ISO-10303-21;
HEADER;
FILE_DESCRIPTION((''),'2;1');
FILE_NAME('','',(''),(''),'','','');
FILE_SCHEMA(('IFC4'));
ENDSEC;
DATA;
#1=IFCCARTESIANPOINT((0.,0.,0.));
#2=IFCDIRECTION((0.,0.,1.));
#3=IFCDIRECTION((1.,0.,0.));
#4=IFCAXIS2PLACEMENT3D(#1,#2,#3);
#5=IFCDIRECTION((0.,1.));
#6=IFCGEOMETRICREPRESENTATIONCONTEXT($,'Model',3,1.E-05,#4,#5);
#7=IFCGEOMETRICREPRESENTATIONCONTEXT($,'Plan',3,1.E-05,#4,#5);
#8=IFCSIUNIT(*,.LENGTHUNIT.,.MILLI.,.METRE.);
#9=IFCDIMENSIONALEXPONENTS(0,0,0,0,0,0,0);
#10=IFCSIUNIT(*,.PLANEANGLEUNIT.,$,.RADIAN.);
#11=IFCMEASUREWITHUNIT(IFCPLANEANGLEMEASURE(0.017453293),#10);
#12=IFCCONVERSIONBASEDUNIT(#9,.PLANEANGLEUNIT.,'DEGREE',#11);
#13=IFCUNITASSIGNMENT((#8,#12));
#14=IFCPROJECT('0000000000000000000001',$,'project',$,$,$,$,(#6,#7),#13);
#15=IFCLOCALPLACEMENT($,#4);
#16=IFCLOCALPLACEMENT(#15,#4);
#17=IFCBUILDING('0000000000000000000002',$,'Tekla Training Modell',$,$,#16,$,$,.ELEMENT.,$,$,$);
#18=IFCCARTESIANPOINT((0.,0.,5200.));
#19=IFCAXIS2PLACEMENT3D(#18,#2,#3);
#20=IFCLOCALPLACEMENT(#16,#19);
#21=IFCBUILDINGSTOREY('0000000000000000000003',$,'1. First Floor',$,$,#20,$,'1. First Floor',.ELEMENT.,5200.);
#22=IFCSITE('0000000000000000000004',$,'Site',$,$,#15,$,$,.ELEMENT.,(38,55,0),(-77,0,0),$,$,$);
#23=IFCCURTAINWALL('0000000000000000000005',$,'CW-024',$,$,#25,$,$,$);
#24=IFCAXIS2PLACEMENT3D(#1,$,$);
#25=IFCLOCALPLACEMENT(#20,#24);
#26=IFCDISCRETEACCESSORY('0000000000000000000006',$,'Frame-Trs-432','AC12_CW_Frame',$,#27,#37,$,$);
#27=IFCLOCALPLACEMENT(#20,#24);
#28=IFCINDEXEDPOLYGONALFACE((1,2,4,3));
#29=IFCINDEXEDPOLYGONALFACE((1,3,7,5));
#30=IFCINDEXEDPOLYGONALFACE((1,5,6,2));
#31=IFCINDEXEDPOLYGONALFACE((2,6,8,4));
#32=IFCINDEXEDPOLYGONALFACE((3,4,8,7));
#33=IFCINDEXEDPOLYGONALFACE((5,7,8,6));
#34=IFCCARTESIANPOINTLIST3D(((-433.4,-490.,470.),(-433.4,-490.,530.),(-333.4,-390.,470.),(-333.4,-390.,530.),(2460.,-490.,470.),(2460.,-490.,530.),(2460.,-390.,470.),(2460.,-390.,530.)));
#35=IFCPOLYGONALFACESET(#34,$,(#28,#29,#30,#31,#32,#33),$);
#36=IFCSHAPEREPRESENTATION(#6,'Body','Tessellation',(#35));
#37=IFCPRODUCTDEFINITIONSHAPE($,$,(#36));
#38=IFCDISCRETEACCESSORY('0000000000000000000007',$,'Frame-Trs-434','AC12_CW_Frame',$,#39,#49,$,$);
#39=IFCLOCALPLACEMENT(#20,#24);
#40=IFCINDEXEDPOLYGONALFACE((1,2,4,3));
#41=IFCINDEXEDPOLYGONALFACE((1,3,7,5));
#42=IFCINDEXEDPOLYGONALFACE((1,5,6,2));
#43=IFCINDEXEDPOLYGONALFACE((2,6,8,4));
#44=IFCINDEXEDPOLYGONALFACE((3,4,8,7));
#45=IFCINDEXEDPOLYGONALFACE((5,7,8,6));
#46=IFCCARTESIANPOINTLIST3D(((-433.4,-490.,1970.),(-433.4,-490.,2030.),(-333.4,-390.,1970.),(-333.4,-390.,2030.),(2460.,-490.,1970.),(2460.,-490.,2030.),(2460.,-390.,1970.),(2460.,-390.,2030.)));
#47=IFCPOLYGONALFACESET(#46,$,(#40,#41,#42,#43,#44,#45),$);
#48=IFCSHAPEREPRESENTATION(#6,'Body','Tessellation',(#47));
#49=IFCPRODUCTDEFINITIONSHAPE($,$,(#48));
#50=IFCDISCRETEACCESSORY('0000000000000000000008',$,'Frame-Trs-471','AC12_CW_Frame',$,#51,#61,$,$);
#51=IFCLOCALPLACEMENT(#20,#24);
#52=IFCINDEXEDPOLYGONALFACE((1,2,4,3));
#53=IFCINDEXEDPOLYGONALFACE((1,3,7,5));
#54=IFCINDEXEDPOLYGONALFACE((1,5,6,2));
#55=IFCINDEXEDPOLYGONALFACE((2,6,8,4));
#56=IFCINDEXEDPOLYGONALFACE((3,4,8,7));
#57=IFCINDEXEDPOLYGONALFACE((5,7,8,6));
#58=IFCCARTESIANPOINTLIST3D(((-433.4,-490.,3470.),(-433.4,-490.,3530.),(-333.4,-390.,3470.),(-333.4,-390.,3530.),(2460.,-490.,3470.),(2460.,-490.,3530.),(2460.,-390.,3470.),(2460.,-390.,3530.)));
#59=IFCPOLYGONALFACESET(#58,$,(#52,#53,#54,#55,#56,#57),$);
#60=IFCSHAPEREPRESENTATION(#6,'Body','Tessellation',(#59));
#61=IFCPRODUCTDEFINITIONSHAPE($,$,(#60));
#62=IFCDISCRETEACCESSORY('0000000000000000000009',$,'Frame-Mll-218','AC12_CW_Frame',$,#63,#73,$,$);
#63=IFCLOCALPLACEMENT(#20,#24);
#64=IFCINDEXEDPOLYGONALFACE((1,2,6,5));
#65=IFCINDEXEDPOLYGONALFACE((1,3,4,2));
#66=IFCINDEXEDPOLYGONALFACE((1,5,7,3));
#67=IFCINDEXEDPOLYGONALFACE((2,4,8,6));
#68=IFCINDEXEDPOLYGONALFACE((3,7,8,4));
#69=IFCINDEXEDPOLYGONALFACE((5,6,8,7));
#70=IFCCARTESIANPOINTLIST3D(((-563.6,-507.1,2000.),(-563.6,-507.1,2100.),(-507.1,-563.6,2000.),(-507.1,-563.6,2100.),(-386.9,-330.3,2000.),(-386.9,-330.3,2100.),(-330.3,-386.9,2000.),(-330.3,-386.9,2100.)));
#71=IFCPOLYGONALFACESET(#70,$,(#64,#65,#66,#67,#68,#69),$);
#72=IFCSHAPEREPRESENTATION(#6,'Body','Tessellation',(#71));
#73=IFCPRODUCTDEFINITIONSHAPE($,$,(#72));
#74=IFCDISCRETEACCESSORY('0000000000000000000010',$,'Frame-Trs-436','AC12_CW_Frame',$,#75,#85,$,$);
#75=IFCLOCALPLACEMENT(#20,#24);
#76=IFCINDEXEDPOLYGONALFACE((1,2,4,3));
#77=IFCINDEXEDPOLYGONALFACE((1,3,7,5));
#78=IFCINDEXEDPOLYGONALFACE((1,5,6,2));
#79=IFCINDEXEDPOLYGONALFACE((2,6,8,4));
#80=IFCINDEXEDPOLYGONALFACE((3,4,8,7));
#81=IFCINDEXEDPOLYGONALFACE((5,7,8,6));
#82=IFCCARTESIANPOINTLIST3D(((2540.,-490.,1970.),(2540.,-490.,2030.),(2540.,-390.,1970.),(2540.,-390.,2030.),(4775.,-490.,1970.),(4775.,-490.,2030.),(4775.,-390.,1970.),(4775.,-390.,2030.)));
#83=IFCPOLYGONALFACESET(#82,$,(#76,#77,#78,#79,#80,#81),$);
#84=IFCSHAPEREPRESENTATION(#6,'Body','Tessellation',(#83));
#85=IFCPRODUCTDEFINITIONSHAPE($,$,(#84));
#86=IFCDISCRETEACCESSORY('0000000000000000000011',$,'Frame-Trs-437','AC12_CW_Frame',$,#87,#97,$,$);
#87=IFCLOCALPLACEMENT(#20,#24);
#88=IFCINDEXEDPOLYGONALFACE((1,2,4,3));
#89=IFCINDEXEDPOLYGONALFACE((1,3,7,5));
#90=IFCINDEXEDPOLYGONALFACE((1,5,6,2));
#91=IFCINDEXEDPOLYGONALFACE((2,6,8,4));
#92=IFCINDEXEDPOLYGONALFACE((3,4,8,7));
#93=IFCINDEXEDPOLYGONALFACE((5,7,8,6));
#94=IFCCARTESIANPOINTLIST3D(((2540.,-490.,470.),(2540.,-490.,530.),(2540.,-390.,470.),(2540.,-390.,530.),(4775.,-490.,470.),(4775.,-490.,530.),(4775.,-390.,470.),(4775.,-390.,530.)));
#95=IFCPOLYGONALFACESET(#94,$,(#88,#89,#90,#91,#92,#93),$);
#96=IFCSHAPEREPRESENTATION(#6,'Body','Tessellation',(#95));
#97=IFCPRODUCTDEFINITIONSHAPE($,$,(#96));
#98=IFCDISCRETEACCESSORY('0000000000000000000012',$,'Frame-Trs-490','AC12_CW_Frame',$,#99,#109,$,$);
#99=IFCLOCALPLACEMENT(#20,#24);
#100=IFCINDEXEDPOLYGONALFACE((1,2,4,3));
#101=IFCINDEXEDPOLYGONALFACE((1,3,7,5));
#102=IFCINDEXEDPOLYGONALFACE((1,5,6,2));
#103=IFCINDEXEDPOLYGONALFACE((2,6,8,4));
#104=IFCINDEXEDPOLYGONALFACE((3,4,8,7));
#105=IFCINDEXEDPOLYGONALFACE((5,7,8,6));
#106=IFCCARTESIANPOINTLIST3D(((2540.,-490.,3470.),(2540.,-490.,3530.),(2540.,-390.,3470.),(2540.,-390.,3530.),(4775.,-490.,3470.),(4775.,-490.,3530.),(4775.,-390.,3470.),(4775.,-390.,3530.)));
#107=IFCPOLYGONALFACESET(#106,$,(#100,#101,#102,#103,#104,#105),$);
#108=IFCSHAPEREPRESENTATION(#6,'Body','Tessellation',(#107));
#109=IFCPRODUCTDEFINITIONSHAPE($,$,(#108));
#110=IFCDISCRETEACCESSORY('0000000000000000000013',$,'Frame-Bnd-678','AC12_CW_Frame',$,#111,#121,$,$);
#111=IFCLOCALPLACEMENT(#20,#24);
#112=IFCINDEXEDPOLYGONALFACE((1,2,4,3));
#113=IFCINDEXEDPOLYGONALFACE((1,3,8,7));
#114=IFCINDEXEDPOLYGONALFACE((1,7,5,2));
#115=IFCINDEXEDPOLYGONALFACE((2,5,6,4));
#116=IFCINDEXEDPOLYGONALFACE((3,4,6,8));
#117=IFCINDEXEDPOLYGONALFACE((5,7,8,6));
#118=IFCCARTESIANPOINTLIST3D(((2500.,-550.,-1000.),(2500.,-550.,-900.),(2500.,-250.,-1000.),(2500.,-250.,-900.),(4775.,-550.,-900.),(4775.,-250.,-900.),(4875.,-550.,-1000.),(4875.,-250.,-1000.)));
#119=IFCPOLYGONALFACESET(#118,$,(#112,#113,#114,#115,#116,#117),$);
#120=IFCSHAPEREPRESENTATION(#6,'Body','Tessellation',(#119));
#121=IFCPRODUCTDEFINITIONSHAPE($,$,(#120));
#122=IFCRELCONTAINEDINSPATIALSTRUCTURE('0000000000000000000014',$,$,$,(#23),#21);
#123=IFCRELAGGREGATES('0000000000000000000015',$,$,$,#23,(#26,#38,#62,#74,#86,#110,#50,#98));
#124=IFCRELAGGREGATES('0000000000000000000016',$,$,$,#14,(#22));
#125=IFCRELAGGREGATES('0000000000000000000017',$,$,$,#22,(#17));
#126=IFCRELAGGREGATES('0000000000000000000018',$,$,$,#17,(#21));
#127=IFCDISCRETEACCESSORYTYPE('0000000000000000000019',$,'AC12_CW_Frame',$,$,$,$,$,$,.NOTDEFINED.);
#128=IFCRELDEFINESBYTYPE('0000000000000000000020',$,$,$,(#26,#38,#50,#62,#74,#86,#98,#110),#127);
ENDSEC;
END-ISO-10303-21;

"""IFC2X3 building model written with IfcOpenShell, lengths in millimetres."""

from ifc_helpers import new_model, entity, si_unit, converted_unit, direction, frame, origin_with_axes, place, context, project, spatial, polyline, outline, extrude, source, transform, mapped, type_object, element, aggregate, save


model = new_model("IFC2X3")

# Units and contexts
model_context = context("Model", 3, precision=1e-05, world=origin_with_axes(), true_north=direction((0.0, 1.0)))
plan_context = context("Plan", 3, precision=1e-05, world=origin_with_axes(), true_north=direction((0.0, 1.0)))
ifc_project = project(units=[si_unit("LENGTHUNIT", "METRE", prefix="MILLI"), converted_unit("PLANEANGLEUNIT", "DEGREE", entity("IfcPlaneAngleMeasure", 0.017453293), si_unit("PLANEANGLEUNIT", "RADIAN"), dimensions=[0, 0, 0, 0, 0, 0, 0])], contexts=[model_context, plan_context])

# Site, building, storey
site_placement = place(None, origin_with_axes())
site = spatial("IfcSite", under=ifc_project, at=site_placement, Name="Site", CompositionType="ELEMENT", RefLatitude=(38, 55, 0), RefLongitude=(-77, 0, 0))
building_placement = place(site_placement, origin_with_axes())
building = spatial("IfcBuilding", under=site, at=building_placement, Name="Tekla Training Modell", CompositionType="ELEMENT")
storey_placement = place(building_placement, frame((0.0, 0.0, 5200.0), z_axis=(0.0, 0.0, 1.0), x_axis=(1.0, 0.0, 0.0)))
storey = spatial("IfcBuildingStorey", under=building, at=storey_placement, Name="1. First Floor", LongName="1. First Floor", CompositionType="ELEMENT", Elevation=5200.0)

# Curtain wall, discrete accessories
curtain_wall_placement = place(storey_placement, frame((-500.0, 6800.2, -1000.0), z_axis=(0.0, 0.0, 1.0), x_axis=(0.0, -1.0, 0.0)))
curtain_wall = element("IfcCurtainWall", 1, at=curtain_wall_placement, inside=storey, Name="CW-024")
discrete_accessory_type = type_object("IfcDiscreteAccessoryType", Name="AC12_CW_Frame")
shared_shape_1 = source(origin_with_axes(), model_context, "Body", "SweptSolid", [
    extrude(outline(polyline([(0.0, 0.0), (141.4, 0.0), (-1904.5, -2046.0), (-1975.3, -1975.3), (0.0, 0.0)])), origin_with_axes(), (0.0, 0.0, 1.0), 60.0),
])
discrete_accessory_1_placement = place(storey_placement, frame((-333.4, -390.0, 530.0), z_axis=(0.0, 0.0, -1.0), x_axis=(-0.707107, -0.707107, 0.0)))
discrete_accessory_1 = element("IfcDiscreteAccessory", 2, at=discrete_accessory_1_placement, type_object=discrete_accessory_type, Name="Frame-Trs-432", Description="AC12_CW_Frame", context=model_context, shape_type="MappedRepresentation", body=[
    mapped(shared_shape_1, transform((0.0, 0.0, 0.0), scale=1.0)),
])
discrete_accessory_2_placement = place(storey_placement, frame((-333.4, -390.0, 2030.0), z_axis=(0.0, 0.0, -1.0), x_axis=(-0.707107, -0.707107, 0.0)))
discrete_accessory_2 = element("IfcDiscreteAccessory", 3, at=discrete_accessory_2_placement, type_object=discrete_accessory_type, Name="Frame-Trs-434", Description="AC12_CW_Frame", context=model_context, shape_type="MappedRepresentation", body=[
    mapped(shared_shape_1, transform((0.0, 0.0, 0.0), scale=1.0)),
])
discrete_accessory_3_placement = place(storey_placement, frame((-333.4, -390.0, 3530.0), z_axis=(0.0, 0.0, -1.0), x_axis=(-0.707107, -0.707107, 0.0)))
discrete_accessory_3 = element("IfcDiscreteAccessory", 4, at=discrete_accessory_3_placement, type_object=discrete_accessory_type, Name="Frame-Trs-471", Description="AC12_CW_Frame", context=model_context, shape_type="MappedRepresentation", body=[
    mapped(shared_shape_1, transform((0.0, 0.0, 0.0), scale=1.0)),
])
shared_shape_2 = source(origin_with_axes(), model_context, "Body", "SweptSolid", [
    extrude(outline(polyline([(0.0, 0.0), (250.0, 0.0), (250.0, -100.0), (0.0, -100.0), (0.0, 0.0)])), origin_with_axes(), (0.0, 0.0, 1.0), 80.0),
])
discrete_accessory_4_placement = place(storey_placement, frame((-386.9, -330.3, 2000.0), z_axis=(0.707107, -0.707107, 0.0), x_axis=(-0.707107, -0.707107, 0.0)))
discrete_accessory_4 = element("IfcDiscreteAccessory", 5, at=discrete_accessory_4_placement, type_object=discrete_accessory_type, Name="Frame-Mll-218", Description="AC12_CW_Frame", context=model_context, shape_type="MappedRepresentation", body=[
    mapped(shared_shape_2, transform((0.0, 0.0, 0.0), scale=1.0)),
])
shared_shape_3 = source(origin_with_axes(), model_context, "Body", "SweptSolid", [
    extrude(outline(polyline([(0.0, 0.0), (100.0, 0.0), (100.0, -2235.0), (0.0, -2235.0), (0.0, 0.0)])), origin_with_axes(), (0.0, 0.0, 1.0), 60.0),
])
discrete_accessory_5_placement = place(storey_placement, frame((2540.0, -390.0, 2030.0), z_axis=(0.0, 0.0, -1.0), x_axis=(0.0, -1.0, 0.0)))
discrete_accessory_5 = element("IfcDiscreteAccessory", 6, at=discrete_accessory_5_placement, type_object=discrete_accessory_type, Name="Frame-Trs-436", Description="AC12_CW_Frame", context=model_context, shape_type="MappedRepresentation", body=[
    mapped(shared_shape_3, transform((0.0, 0.0, 0.0), scale=1.0)),
])
discrete_accessory_6_placement = place(storey_placement, frame((2540.0, -390.0, 530.0), z_axis=(0.0, 0.0, -1.0), x_axis=(0.0, -1.0, 0.0)))
discrete_accessory_6 = element("IfcDiscreteAccessory", 7, at=discrete_accessory_6_placement, type_object=discrete_accessory_type, Name="Frame-Trs-437", Description="AC12_CW_Frame", context=model_context, shape_type="MappedRepresentation", body=[
    mapped(shared_shape_3, transform((0.0, 0.0, 0.0), scale=1.0)),
])
discrete_accessory_7_placement = place(storey_placement, frame((2540.0, -390.0, 3530.0), z_axis=(0.0, 0.0, -1.0), x_axis=(0.0, -1.0, 0.0)))
discrete_accessory_7 = element("IfcDiscreteAccessory", 8, at=discrete_accessory_7_placement, type_object=discrete_accessory_type, Name="Frame-Trs-490", Description="AC12_CW_Frame", context=model_context, shape_type="MappedRepresentation", body=[
    mapped(shared_shape_3, transform((0.0, 0.0, 0.0), scale=1.0)),
])
shared_shape_4 = source(origin_with_axes(), model_context, "Body", "SweptSolid", [
    extrude(outline(polyline([(0.0, 0.0), (100.0, 0.0), (100.0, -2375.0), (0.0, -2275.0), (0.0, 0.0)])), origin_with_axes(), (0.0, 0.0, 1.0), 300.0),
])
discrete_accessory_8_placement = place(storey_placement, frame((2500.0, -550.0, -900.0), z_axis=(0.0, 1.0, 0.0), x_axis=(0.0, 0.0, -1.0)))
discrete_accessory_8 = element("IfcDiscreteAccessory", 9, at=discrete_accessory_8_placement, type_object=discrete_accessory_type, Name="Frame-Bnd-678", Description="AC12_CW_Frame", context=model_context, shape_type="MappedRepresentation", body=[
    mapped(shared_shape_4, transform((0.0, 0.0, 0.0), scale=1.0)),
])
aggregate(curtain_wall, [discrete_accessory_1, discrete_accessory_2, discrete_accessory_4, discrete_accessory_5, discrete_accessory_6, discrete_accessory_8, discrete_accessory_3, discrete_accessory_7])

save(model, "model.ifc")
